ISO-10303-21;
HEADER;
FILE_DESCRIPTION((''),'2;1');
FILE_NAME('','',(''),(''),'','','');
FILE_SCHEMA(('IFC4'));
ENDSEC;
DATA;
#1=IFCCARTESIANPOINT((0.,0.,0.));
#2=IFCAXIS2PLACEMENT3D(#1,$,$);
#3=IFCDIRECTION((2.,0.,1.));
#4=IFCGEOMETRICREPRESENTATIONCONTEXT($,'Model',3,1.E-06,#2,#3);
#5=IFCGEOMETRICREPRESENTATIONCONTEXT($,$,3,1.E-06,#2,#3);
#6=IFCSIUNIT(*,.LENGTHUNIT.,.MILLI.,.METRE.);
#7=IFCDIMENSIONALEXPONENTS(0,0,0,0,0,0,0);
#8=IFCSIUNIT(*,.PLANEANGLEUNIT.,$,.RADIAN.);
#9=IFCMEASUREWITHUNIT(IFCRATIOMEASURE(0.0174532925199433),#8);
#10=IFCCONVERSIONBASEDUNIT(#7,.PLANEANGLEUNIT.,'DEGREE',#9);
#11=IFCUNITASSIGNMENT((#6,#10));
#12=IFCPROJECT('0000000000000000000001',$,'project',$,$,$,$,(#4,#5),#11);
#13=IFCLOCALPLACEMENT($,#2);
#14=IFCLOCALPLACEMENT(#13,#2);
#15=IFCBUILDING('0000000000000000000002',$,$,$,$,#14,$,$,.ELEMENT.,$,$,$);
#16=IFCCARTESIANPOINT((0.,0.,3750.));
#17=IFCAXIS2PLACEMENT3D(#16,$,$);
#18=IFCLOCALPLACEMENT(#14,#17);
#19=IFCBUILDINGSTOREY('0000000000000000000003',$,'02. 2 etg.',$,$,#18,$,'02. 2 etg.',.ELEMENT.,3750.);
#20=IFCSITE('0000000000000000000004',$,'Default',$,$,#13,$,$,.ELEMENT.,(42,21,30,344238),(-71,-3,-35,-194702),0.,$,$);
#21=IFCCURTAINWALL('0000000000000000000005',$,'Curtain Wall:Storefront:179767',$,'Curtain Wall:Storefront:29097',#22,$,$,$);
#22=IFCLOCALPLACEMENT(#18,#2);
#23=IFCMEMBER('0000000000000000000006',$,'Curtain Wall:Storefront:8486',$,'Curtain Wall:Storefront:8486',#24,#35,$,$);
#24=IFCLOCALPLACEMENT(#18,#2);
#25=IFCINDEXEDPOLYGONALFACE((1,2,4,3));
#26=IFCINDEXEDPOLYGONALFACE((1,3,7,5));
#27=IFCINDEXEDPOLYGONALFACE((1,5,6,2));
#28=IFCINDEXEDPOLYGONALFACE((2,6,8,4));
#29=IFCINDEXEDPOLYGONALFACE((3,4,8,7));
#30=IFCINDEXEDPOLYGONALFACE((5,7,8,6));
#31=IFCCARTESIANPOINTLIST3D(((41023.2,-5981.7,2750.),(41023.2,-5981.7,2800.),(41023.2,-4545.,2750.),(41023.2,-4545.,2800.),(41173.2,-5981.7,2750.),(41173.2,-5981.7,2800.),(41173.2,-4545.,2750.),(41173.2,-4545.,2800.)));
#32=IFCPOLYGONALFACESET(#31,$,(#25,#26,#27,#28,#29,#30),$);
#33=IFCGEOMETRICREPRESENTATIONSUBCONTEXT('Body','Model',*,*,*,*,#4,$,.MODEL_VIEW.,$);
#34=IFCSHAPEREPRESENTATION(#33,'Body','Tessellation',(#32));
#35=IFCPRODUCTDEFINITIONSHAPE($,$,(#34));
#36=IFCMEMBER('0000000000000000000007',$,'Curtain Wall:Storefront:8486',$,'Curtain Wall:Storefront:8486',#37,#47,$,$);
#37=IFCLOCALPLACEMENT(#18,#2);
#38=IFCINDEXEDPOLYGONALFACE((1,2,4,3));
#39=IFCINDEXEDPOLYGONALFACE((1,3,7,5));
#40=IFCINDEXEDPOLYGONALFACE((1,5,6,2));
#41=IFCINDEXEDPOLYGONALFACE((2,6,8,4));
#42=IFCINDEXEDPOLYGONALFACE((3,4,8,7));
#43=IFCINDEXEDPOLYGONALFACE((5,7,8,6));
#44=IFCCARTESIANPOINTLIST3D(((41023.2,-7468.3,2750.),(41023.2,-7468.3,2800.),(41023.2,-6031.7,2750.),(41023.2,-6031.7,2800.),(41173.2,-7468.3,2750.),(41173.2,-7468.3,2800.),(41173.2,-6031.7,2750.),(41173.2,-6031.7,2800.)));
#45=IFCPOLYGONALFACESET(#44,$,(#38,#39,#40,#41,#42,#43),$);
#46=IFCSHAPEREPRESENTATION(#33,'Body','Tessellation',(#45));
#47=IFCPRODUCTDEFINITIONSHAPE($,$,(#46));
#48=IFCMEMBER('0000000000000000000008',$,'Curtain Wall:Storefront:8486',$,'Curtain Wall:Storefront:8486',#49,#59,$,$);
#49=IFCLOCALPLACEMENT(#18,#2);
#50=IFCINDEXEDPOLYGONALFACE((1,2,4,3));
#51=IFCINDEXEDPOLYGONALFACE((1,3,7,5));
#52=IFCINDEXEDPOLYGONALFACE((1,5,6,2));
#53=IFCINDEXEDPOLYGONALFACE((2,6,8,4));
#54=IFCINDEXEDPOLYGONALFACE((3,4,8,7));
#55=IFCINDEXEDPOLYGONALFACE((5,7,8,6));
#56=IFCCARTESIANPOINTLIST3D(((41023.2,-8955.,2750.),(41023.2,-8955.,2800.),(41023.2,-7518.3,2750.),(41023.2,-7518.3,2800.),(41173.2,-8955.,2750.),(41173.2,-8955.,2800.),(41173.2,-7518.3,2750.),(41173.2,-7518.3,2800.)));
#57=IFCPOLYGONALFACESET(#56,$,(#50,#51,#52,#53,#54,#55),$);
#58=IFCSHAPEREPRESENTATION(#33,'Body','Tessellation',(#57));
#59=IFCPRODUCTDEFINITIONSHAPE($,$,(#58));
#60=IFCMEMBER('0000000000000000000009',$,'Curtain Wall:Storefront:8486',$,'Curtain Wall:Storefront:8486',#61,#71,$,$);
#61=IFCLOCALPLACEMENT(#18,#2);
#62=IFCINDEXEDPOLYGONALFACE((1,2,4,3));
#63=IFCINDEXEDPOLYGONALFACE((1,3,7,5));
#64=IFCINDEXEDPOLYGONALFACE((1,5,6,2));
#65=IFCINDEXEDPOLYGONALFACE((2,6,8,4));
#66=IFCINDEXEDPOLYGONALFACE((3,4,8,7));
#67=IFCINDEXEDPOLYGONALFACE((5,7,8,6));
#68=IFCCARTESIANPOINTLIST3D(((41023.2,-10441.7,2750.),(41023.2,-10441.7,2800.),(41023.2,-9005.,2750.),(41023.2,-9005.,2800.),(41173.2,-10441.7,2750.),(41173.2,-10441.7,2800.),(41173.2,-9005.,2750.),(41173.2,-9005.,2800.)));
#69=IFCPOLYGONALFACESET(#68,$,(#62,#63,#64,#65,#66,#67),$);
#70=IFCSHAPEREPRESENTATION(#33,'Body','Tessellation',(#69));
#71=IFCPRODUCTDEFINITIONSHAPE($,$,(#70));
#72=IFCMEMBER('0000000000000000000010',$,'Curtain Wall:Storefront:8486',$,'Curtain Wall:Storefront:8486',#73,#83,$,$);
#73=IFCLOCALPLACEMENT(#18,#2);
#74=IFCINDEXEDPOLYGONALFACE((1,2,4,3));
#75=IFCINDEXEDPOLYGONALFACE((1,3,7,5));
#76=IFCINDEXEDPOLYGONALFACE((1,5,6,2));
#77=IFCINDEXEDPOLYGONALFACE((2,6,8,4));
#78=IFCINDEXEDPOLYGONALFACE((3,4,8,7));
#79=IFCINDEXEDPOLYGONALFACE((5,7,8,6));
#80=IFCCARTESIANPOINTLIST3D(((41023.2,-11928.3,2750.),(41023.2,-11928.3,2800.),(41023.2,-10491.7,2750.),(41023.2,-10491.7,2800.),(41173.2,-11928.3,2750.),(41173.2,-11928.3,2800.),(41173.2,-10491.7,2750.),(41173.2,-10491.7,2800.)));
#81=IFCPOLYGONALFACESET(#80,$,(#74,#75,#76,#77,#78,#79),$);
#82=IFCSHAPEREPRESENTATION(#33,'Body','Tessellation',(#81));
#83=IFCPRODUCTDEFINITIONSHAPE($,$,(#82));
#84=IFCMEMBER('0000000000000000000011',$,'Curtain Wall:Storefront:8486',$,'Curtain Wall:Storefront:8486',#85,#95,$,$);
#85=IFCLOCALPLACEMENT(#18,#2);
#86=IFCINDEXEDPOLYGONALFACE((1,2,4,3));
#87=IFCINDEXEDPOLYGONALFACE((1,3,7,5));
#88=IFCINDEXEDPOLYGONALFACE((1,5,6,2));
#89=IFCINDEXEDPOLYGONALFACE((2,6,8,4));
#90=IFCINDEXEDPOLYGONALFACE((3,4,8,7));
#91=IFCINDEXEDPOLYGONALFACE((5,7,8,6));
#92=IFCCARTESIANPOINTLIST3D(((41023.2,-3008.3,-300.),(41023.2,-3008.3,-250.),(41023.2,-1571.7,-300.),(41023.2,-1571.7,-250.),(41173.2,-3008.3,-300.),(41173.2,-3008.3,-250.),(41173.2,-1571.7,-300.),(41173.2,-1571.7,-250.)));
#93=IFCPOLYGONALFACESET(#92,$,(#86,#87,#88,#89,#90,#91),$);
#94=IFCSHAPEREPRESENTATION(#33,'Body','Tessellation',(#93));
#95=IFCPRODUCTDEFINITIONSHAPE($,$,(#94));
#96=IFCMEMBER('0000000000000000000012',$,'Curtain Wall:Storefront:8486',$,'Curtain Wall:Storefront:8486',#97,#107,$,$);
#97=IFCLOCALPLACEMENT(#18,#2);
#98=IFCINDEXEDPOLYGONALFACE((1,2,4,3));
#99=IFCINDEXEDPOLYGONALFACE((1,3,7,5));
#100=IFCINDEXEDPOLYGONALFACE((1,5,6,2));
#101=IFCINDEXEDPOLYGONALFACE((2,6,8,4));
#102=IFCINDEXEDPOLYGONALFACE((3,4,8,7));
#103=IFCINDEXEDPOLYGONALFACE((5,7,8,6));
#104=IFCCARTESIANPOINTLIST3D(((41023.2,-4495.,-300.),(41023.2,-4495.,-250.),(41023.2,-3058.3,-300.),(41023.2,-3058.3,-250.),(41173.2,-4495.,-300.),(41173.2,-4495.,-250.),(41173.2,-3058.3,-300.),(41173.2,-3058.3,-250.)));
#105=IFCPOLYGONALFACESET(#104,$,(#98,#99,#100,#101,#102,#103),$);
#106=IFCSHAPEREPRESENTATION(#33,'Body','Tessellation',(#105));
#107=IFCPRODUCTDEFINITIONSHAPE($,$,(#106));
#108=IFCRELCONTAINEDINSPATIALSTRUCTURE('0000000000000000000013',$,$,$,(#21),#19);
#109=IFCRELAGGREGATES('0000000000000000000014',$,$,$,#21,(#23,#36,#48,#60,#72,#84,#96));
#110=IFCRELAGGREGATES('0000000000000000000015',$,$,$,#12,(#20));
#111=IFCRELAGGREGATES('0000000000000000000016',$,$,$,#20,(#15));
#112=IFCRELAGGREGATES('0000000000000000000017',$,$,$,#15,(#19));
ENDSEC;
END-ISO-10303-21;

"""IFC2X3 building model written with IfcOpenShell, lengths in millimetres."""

from ifc_helpers import new_model, entity, si_unit, converted_unit, direction, frame, frame_2d, origin, origin_2d_with_axis, place, context, subcontext, project, spatial, rectangle, extrude, element, aggregate, save


model = new_model("IFC2X3")

# Units and contexts
model_context = context("Model", 3, precision=1e-06, world=origin(), true_north=direction((2.0, 0.0, 1.0)))
context_of_model = context(None, 3, precision=1e-06, world=origin(), true_north=direction((2.0, 0.0, 1.0)))
body_context = subcontext(model_context, "Body", "Model", "MODEL_VIEW")
ifc_project = project(units=[si_unit("LENGTHUNIT", "METRE", prefix="MILLI"), converted_unit("PLANEANGLEUNIT", "DEGREE", entity("IfcRatioMeasure", 0.0174532925199433), si_unit("PLANEANGLEUNIT", "RADIAN"), dimensions=[0, 0, 0, 0, 0, 0, 0])], contexts=[model_context, context_of_model])

# Site, building, storey
site_placement = place(None, origin())
site = spatial("IfcSite", under=ifc_project, at=site_placement, Name="Default", CompositionType="ELEMENT", RefLatitude=(42, 21, 30, 344238), RefLongitude=(-71, -3, -35, -194702), RefElevation=0.0)
building_placement = place(site_placement, origin())
building = spatial("IfcBuilding", under=site, at=building_placement, CompositionType="ELEMENT")
storey_placement = place(building_placement, frame((0.0, 0.0, 3750.0)))
storey = spatial("IfcBuildingStorey", under=building, at=storey_placement, Name="02. 2 etg.", LongName="02. 2 etg.", CompositionType="ELEMENT", Elevation=3750.0)

# Curtain wall, members
curtain_wall_1_placement = place(storey_placement, origin())
curtain_wall_1 = element("IfcCurtainWall", 1, at=curtain_wall_1_placement, inside=storey, Name="Curtain Wall:Storefront:179767", ObjectType="Curtain Wall:Storefront:29097")
member_1_placement = place(storey_placement, origin())
member_1 = element("IfcMember", 2, at=member_1_placement, Name="Curtain Wall:Storefront:8486", ObjectType="Curtain Wall:Storefront:8486", context=body_context, shape_type="SweptSolid", body=[
    extrude(rectangle(XDim=1436.7, YDim=150.0, at=frame_2d((0.0, 0.0), x_axis=(1.0, 0.0))), frame((41098.2, -5263.3, 2750.0), z_axis=(0.0, 0.0, 1.0), x_axis=(0.0, 1.0, 0.0)), (0.0, 0.0, 1.0), 50.0),
])
member_2_placement = place(storey_placement, origin())
member_2 = element("IfcMember", 3, at=member_2_placement, Name="Curtain Wall:Storefront:8486", ObjectType="Curtain Wall:Storefront:8486", context=body_context, shape_type="SweptSolid", body=[
    extrude(rectangle(XDim=1436.7, YDim=150.0, at=frame_2d((0.0, 0.0), x_axis=(1.0, 0.0))), frame((41098.2, -6750.0, 2750.0), z_axis=(0.0, 0.0, 1.0), x_axis=(0.0, 1.0, 0.0)), (0.0, 0.0, 1.0), 50.0),
])
member_3_placement = place(storey_placement, origin())
member_3 = element("IfcMember", 4, at=member_3_placement, Name="Curtain Wall:Storefront:8486", ObjectType="Curtain Wall:Storefront:8486", context=body_context, shape_type="SweptSolid", body=[
    extrude(rectangle(XDim=1436.7, YDim=150.0, at=frame_2d((0.0, 0.0), x_axis=(1.0, 0.0))), frame((41098.2, -8236.7, 2750.0), z_axis=(0.0, 0.0, 1.0), x_axis=(0.0, 1.0, 0.0)), (0.0, 0.0, 1.0), 50.0),
])
member_4_placement = place(storey_placement, origin())
member_4 = element("IfcMember", 5, at=member_4_placement, Name="Curtain Wall:Storefront:8486", ObjectType="Curtain Wall:Storefront:8486", context=body_context, shape_type="SweptSolid", body=[
    extrude(rectangle(XDim=1436.7, YDim=150.0, at=frame_2d((0.0, 0.0), x_axis=(1.0, 0.0))), frame((41098.2, -9723.3, 2750.0), z_axis=(0.0, 0.0, 1.0), x_axis=(0.0, 1.0, 0.0)), (0.0, 0.0, 1.0), 50.0),
])
member_5_placement = place(storey_placement, origin())
member_5 = element("IfcMember", 6, at=member_5_placement, Name="Curtain Wall:Storefront:8486", ObjectType="Curtain Wall:Storefront:8486", context=body_context, shape_type="SweptSolid", body=[
    extrude(rectangle(XDim=1436.7, YDim=150.0, at=origin_2d_with_axis()), frame((41098.2, -11210.0, 2750.0), z_axis=(0.0, 0.0, 1.0), x_axis=(0.0, 1.0, 0.0)), (0.0, 0.0, 1.0), 50.0),
])
member_6_placement = place(storey_placement, origin())
member_6 = element("IfcMember", 7, at=member_6_placement, Name="Curtain Wall:Storefront:8486", ObjectType="Curtain Wall:Storefront:8486", context=body_context, shape_type="SweptSolid", body=[
    extrude(rectangle(XDim=1436.7, YDim=150.0, at=frame_2d((0.0, 0.0), x_axis=(1.0, 0.0))), frame((41098.2, -2290.0, -300.0), z_axis=(0.0, 0.0, 1.0), x_axis=(0.0, -1.0, 0.0)), (0.0, 0.0, 1.0), 50.0),
])
member_7_placement = place(storey_placement, origin())
member_7 = element("IfcMember", 8, at=member_7_placement, Name="Curtain Wall:Storefront:8486", ObjectType="Curtain Wall:Storefront:8486", context=body_context, shape_type="SweptSolid", body=[
    extrude(rectangle(XDim=1436.7, YDim=150.0, at=origin_2d_with_axis()), frame((41098.2, -3776.7, -300.0), z_axis=(0.0, 0.0, 1.0), x_axis=(0.0, -1.0, 0.0)), (0.0, 0.0, 1.0), 50.0),
])
aggregate(curtain_wall_1, [member_1, member_2, member_3, member_4, member_5, member_6, member_7])

save(model, "model.ifc")
